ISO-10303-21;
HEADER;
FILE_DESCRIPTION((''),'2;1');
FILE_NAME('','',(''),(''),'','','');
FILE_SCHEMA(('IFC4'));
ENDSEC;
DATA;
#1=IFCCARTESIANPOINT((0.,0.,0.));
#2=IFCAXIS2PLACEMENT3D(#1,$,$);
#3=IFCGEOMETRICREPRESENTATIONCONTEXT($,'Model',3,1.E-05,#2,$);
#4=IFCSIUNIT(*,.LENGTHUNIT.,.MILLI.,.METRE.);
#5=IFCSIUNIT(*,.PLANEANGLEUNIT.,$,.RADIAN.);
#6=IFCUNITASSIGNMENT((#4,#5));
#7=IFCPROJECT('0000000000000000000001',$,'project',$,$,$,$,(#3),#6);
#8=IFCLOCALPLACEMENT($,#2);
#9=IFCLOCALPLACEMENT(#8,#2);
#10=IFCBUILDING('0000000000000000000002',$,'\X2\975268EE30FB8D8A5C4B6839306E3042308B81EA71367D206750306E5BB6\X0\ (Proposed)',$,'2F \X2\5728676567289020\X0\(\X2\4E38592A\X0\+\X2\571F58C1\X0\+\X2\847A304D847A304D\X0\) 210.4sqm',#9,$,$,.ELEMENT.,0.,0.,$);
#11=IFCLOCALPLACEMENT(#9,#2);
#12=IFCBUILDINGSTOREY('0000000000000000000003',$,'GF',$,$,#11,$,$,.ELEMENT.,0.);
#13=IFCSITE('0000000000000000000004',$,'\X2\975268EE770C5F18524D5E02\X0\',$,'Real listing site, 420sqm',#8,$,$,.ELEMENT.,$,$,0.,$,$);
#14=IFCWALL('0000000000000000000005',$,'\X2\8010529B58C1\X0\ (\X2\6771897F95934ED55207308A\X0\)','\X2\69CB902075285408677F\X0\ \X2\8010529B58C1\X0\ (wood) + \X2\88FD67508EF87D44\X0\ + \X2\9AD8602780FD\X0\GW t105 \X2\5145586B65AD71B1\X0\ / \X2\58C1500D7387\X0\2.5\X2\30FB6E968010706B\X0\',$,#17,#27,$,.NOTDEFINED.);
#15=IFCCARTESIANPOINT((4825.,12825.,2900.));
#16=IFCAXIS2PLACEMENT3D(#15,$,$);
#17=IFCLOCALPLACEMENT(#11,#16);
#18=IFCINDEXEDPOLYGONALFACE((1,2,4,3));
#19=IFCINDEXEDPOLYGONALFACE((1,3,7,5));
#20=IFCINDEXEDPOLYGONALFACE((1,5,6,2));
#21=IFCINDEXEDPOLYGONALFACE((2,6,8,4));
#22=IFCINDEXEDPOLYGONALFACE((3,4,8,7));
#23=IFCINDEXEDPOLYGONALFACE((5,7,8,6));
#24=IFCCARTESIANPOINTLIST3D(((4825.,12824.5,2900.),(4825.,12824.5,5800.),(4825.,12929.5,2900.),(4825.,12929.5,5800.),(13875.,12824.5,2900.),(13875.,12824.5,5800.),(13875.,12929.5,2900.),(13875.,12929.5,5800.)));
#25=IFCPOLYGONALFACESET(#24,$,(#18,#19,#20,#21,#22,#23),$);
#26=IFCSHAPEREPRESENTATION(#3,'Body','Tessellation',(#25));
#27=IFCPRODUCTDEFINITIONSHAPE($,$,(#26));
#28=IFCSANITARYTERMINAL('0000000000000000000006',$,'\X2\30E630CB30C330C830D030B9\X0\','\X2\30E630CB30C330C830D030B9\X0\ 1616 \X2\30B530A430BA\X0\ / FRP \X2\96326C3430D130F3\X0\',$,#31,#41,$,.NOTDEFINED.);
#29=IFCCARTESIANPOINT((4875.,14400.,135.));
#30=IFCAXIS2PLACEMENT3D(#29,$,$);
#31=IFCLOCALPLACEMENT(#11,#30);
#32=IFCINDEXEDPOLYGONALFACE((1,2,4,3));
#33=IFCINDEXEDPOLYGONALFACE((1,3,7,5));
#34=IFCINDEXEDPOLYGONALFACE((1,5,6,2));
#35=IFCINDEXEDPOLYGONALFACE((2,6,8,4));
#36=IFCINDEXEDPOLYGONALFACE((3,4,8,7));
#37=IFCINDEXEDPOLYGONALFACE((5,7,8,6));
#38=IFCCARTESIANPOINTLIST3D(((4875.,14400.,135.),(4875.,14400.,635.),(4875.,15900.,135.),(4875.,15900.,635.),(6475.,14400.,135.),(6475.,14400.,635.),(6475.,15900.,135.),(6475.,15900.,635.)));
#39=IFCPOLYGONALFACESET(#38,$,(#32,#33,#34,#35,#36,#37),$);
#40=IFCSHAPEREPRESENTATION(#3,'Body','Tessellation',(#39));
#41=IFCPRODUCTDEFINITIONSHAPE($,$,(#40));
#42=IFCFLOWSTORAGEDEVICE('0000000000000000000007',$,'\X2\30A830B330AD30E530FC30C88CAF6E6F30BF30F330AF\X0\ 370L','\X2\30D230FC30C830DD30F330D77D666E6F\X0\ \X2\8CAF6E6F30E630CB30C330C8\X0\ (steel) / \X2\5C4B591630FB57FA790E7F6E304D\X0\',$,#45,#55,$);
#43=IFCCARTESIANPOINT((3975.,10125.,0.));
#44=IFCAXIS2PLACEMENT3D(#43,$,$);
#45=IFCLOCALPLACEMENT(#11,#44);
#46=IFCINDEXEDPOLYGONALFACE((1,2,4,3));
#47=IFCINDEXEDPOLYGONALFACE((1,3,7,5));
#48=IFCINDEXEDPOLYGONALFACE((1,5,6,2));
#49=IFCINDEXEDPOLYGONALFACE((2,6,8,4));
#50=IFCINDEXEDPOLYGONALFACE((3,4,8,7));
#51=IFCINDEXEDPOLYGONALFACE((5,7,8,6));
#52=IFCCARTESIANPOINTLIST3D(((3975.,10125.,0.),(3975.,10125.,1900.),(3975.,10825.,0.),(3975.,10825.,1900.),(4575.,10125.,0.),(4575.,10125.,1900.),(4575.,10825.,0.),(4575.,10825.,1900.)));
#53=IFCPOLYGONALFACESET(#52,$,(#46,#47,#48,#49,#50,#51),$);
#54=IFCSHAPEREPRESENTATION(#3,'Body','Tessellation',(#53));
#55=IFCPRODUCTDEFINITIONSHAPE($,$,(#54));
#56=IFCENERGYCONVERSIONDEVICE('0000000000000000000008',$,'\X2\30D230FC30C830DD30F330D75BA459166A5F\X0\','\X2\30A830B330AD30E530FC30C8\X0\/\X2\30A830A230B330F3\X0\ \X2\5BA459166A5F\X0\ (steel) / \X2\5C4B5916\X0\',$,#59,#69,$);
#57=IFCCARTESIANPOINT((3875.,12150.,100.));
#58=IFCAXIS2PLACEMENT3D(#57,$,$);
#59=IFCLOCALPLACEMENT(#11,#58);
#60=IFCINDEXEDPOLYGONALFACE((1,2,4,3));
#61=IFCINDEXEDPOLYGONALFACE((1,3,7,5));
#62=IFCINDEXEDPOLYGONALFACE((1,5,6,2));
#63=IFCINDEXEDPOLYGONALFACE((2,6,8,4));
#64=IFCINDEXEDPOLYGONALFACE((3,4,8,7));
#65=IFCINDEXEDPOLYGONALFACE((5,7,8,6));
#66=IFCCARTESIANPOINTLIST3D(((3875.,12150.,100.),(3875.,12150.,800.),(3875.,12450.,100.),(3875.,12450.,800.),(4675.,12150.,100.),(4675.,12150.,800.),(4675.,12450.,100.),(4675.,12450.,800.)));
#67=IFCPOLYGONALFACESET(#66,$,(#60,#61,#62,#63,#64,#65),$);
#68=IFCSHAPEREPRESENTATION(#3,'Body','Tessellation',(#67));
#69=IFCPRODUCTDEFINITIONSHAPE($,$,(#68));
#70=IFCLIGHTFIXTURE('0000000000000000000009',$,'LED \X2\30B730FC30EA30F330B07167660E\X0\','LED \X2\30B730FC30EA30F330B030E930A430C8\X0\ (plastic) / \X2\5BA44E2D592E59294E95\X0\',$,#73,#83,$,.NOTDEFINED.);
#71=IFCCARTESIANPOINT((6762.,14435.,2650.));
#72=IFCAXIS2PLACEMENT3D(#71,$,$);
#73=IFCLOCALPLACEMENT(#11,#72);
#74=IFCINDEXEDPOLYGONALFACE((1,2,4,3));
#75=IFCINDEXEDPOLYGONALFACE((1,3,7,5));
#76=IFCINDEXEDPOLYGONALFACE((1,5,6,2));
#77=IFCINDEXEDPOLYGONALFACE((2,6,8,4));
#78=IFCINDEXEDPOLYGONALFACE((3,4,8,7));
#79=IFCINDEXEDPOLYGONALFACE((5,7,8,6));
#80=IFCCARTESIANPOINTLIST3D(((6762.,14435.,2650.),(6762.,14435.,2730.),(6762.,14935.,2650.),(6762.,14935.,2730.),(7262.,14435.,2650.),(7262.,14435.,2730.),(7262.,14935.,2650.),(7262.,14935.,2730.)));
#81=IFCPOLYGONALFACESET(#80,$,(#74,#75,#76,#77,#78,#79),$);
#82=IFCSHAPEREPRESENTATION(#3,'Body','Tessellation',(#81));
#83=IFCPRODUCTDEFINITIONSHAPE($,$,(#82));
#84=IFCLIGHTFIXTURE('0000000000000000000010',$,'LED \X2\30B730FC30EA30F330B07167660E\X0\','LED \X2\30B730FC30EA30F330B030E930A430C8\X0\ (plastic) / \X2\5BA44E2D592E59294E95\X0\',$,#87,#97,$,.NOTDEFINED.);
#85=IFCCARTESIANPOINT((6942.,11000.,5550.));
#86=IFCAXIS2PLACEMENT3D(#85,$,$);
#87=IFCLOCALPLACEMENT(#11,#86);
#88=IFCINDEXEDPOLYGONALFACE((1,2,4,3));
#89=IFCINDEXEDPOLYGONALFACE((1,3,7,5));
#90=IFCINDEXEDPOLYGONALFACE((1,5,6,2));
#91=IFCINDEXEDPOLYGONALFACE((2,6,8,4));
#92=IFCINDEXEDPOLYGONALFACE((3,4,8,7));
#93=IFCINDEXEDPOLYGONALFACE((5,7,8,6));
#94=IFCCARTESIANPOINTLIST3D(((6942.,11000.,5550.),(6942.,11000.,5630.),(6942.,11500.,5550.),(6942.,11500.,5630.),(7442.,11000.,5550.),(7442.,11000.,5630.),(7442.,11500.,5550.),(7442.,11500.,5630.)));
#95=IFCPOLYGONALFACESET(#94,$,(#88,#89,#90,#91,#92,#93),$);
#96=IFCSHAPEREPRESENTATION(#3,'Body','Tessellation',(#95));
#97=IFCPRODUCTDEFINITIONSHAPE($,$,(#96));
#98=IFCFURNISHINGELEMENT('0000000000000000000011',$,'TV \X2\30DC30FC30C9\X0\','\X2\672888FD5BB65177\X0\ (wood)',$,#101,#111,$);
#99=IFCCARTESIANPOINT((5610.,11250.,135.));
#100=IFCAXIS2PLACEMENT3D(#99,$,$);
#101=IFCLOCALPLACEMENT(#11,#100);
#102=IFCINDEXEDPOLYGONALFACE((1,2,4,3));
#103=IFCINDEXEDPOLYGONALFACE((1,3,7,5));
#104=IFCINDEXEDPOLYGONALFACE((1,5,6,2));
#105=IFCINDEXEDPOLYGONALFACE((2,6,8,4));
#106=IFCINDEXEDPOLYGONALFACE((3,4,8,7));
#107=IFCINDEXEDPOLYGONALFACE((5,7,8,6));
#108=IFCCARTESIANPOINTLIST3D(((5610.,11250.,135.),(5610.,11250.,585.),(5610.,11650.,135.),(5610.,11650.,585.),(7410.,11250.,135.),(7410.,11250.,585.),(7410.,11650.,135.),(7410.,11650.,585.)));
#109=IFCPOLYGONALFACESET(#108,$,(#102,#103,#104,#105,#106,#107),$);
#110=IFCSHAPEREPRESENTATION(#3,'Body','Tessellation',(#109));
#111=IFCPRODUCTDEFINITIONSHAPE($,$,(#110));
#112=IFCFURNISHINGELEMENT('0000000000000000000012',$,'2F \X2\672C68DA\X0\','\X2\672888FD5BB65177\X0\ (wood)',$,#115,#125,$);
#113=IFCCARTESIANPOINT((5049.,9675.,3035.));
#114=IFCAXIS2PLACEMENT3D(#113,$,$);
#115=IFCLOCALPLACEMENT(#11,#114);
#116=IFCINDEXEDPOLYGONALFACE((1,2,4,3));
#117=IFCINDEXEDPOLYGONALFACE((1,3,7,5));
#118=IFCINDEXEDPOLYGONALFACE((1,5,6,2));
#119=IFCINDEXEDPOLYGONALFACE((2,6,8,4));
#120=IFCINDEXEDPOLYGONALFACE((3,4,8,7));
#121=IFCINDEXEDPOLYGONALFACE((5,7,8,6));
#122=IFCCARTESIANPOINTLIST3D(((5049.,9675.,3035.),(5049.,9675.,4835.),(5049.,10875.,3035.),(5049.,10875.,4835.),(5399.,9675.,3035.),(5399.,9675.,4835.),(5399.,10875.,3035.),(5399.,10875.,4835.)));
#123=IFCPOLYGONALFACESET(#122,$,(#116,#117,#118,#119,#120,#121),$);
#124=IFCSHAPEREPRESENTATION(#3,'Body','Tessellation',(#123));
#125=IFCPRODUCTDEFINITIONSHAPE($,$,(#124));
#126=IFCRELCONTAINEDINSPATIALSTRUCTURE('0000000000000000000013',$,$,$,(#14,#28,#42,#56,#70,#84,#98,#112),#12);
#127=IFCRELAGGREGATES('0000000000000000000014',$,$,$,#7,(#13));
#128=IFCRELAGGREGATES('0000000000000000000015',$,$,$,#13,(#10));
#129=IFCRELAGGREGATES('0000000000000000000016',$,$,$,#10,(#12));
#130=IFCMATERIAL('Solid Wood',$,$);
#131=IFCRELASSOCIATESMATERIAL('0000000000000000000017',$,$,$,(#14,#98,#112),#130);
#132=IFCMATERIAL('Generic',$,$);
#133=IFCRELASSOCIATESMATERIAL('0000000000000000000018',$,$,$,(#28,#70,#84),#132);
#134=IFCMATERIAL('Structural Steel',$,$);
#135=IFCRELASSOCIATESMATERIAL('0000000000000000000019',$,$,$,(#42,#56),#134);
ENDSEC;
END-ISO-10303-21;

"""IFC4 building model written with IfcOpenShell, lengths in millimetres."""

from ifc_helpers import new_model, si_unit, frame, frame_2d, origin, place, context, project, spatial, rectangle, extrude, material, element, save


model = new_model("IFC4")

# Units and contexts
model_context = context("Model", 3, precision=1e-05, world=origin())
ifc_project = project(units=[si_unit("LENGTHUNIT", "METRE", prefix="MILLI"), si_unit("PLANEANGLEUNIT", "RADIAN")], contexts=[model_context])

# Site, building, storey
site_placement = place(None, origin())
site = spatial("IfcSite", under=ifc_project, at=site_placement, Name="青森県弘前市", ObjectType="Real listing site, 420sqm", CompositionType="ELEMENT", RefElevation=0.0)
building_placement = place(site_placement, origin())
building = spatial("IfcBuilding", under=site, at=building_placement, Name="青森・越屋根のある自然素材の家 (Proposed)", ObjectType="2F 在来木造(丸太+土壁+葺き葺き) 210.4sqm", CompositionType="ELEMENT", ElevationOfRefHeight=0.0, ElevationOfTerrain=0.0)
storey_placement = place(building_placement, origin())
storey = spatial("IfcBuildingStorey", under=building, at=storey_placement, Name="GF", CompositionType="ELEMENT", Elevation=0.0)

# Shared definitions
ifc_material_1 = material(Name="Solid Wood")

# Wall
wall_1_placement = place(storey_placement, frame((4825.0, 12825.0, 2900.0)))
element("IfcWall", 1, at=wall_1_placement, inside=storey, material=ifc_material_1, Name="耐力壁 (東西間仕切り)", Description="構造用合板 耐力壁 (wood) + 製材軸組 + 高性能GW t105 充填断熱 / 壁倍率2.5・準耐火", PredefinedType="NOTDEFINED", context=model_context, shape_type="SweptSolid", body=[
    extrude(rectangle(XDim=9050.0, YDim=105.0, at=frame_2d((4525.0, 52.0))), frame((4825.0, 12825.0, 2900.0)), (0.0, 0.0, 1.0), 2900.0),
])

# Sanitary terminal
ifc_material_2 = material(Name="Generic")
sanitary_terminal_placement = place(storey_placement, frame((4875.0, 14400.0, 135.0)))
element("IfcSanitaryTerminal", 2, at=sanitary_terminal_placement, inside=storey, material=ifc_material_2, Name="ユニットバス", Description="ユニットバス 1616 サイズ / FRP 防水パン", PredefinedType="NOTDEFINED", context=model_context, shape_type="SweptSolid", body=[
    extrude(rectangle(XDim=1600.0, YDim=1500.0, at=frame_2d((800.0, 750.0))), frame((4875.0, 14400.0, 135.0)), (0.0, 0.0, 1.0), 500.0),
])

# Flow storage device
ifc_material_3 = material(Name="Structural Steel")
flow_storage_device_placement = place(storey_placement, frame((3975.0, 10125.0, 0.0)))
element("IfcFlowStorageDevice", 3, at=flow_storage_device_placement, inside=storey, material=ifc_material_3, Name="エコキュート貯湯タンク 370L", Description="ヒートポンプ給湯 貯湯ユニット (steel) / 屋外・基礎置き", context=model_context, shape_type="SweptSolid", body=[
    extrude(rectangle(XDim=600.0, YDim=700.0, at=frame_2d((300.0, 350.0))), frame((3975.0, 10125.0, 0.0)), (0.0, 0.0, 1.0), 1900.0),
])

# Energy conversion device
energy_conversion_device_placement = place(storey_placement, frame((3875.0, 12150.0, 100.0)))
element("IfcEnergyConversionDevice", 4, at=energy_conversion_device_placement, inside=storey, material=ifc_material_3, Name="ヒートポンプ室外機", Description="エコキュート/エアコン 室外機 (steel) / 屋外", context=model_context, shape_type="SweptSolid", body=[
    extrude(rectangle(XDim=800.0, YDim=300.0, at=frame_2d((400.0, 150.0))), frame((3875.0, 12150.0, 100.0)), (0.0, 0.0, 1.0), 700.0),
])

# Light fixtures
light_fixture_1_placement = place(storey_placement, frame((6762.0, 14435.0, 2650.0)))
element("IfcLightFixture", 5, at=light_fixture_1_placement, inside=storey, material=ifc_material_2, Name="LED シーリング照明", Description="LED シーリングライト (plastic) / 室中央天井", PredefinedType="NOTDEFINED", context=model_context, shape_type="SweptSolid", body=[
    extrude(rectangle(XDim=500.0, YDim=500.0, at=frame_2d((250.0, 250.0))), frame((6762.0, 14435.0, 2650.0)), (0.0, 0.0, 1.0), 80.0),
])
light_fixture_2_placement = place(storey_placement, frame((6942.0, 11000.0, 5550.0)))
element("IfcLightFixture", 6, at=light_fixture_2_placement, inside=storey, material=ifc_material_2, Name="LED シーリング照明", Description="LED シーリングライト (plastic) / 室中央天井", PredefinedType="NOTDEFINED", context=model_context, shape_type="SweptSolid", body=[
    extrude(rectangle(XDim=500.0, YDim=500.0, at=frame_2d((250.0, 250.0))), frame((6942.0, 11000.0, 5550.0)), (0.0, 0.0, 1.0), 80.0),
])

# Furnishing elements
furnishing_1_placement = place(storey_placement, frame((5610.0, 11250.0, 135.0)))
element("IfcFurnishingElement", 7, at=furnishing_1_placement, inside=storey, material=ifc_material_1, Name="TV ボード", Description="木製家具 (wood)", context=model_context, shape_type="SweptSolid", body=[
    extrude(rectangle(XDim=1800.0, YDim=400.0, at=frame_2d((900.0, 200.0))), frame((5610.0, 11250.0, 135.0)), (0.0, 0.0, 1.0), 450.0),
])
furnishing_2_placement = place(storey_placement, frame((5049.0, 9675.0, 3035.0)))
element("IfcFurnishingElement", 8, at=furnishing_2_placement, inside=storey, material=ifc_material_1, Name="2F 本棚", Description="木製家具 (wood)", context=model_context, shape_type="SweptSolid", body=[
    extrude(rectangle(XDim=350.0, YDim=1200.0, at=frame_2d((175.0, 600.0))), frame((5049.0, 9675.0, 3035.0)), (0.0, 0.0, 1.0), 1800.0),
])

save(model, "model.ifc")
